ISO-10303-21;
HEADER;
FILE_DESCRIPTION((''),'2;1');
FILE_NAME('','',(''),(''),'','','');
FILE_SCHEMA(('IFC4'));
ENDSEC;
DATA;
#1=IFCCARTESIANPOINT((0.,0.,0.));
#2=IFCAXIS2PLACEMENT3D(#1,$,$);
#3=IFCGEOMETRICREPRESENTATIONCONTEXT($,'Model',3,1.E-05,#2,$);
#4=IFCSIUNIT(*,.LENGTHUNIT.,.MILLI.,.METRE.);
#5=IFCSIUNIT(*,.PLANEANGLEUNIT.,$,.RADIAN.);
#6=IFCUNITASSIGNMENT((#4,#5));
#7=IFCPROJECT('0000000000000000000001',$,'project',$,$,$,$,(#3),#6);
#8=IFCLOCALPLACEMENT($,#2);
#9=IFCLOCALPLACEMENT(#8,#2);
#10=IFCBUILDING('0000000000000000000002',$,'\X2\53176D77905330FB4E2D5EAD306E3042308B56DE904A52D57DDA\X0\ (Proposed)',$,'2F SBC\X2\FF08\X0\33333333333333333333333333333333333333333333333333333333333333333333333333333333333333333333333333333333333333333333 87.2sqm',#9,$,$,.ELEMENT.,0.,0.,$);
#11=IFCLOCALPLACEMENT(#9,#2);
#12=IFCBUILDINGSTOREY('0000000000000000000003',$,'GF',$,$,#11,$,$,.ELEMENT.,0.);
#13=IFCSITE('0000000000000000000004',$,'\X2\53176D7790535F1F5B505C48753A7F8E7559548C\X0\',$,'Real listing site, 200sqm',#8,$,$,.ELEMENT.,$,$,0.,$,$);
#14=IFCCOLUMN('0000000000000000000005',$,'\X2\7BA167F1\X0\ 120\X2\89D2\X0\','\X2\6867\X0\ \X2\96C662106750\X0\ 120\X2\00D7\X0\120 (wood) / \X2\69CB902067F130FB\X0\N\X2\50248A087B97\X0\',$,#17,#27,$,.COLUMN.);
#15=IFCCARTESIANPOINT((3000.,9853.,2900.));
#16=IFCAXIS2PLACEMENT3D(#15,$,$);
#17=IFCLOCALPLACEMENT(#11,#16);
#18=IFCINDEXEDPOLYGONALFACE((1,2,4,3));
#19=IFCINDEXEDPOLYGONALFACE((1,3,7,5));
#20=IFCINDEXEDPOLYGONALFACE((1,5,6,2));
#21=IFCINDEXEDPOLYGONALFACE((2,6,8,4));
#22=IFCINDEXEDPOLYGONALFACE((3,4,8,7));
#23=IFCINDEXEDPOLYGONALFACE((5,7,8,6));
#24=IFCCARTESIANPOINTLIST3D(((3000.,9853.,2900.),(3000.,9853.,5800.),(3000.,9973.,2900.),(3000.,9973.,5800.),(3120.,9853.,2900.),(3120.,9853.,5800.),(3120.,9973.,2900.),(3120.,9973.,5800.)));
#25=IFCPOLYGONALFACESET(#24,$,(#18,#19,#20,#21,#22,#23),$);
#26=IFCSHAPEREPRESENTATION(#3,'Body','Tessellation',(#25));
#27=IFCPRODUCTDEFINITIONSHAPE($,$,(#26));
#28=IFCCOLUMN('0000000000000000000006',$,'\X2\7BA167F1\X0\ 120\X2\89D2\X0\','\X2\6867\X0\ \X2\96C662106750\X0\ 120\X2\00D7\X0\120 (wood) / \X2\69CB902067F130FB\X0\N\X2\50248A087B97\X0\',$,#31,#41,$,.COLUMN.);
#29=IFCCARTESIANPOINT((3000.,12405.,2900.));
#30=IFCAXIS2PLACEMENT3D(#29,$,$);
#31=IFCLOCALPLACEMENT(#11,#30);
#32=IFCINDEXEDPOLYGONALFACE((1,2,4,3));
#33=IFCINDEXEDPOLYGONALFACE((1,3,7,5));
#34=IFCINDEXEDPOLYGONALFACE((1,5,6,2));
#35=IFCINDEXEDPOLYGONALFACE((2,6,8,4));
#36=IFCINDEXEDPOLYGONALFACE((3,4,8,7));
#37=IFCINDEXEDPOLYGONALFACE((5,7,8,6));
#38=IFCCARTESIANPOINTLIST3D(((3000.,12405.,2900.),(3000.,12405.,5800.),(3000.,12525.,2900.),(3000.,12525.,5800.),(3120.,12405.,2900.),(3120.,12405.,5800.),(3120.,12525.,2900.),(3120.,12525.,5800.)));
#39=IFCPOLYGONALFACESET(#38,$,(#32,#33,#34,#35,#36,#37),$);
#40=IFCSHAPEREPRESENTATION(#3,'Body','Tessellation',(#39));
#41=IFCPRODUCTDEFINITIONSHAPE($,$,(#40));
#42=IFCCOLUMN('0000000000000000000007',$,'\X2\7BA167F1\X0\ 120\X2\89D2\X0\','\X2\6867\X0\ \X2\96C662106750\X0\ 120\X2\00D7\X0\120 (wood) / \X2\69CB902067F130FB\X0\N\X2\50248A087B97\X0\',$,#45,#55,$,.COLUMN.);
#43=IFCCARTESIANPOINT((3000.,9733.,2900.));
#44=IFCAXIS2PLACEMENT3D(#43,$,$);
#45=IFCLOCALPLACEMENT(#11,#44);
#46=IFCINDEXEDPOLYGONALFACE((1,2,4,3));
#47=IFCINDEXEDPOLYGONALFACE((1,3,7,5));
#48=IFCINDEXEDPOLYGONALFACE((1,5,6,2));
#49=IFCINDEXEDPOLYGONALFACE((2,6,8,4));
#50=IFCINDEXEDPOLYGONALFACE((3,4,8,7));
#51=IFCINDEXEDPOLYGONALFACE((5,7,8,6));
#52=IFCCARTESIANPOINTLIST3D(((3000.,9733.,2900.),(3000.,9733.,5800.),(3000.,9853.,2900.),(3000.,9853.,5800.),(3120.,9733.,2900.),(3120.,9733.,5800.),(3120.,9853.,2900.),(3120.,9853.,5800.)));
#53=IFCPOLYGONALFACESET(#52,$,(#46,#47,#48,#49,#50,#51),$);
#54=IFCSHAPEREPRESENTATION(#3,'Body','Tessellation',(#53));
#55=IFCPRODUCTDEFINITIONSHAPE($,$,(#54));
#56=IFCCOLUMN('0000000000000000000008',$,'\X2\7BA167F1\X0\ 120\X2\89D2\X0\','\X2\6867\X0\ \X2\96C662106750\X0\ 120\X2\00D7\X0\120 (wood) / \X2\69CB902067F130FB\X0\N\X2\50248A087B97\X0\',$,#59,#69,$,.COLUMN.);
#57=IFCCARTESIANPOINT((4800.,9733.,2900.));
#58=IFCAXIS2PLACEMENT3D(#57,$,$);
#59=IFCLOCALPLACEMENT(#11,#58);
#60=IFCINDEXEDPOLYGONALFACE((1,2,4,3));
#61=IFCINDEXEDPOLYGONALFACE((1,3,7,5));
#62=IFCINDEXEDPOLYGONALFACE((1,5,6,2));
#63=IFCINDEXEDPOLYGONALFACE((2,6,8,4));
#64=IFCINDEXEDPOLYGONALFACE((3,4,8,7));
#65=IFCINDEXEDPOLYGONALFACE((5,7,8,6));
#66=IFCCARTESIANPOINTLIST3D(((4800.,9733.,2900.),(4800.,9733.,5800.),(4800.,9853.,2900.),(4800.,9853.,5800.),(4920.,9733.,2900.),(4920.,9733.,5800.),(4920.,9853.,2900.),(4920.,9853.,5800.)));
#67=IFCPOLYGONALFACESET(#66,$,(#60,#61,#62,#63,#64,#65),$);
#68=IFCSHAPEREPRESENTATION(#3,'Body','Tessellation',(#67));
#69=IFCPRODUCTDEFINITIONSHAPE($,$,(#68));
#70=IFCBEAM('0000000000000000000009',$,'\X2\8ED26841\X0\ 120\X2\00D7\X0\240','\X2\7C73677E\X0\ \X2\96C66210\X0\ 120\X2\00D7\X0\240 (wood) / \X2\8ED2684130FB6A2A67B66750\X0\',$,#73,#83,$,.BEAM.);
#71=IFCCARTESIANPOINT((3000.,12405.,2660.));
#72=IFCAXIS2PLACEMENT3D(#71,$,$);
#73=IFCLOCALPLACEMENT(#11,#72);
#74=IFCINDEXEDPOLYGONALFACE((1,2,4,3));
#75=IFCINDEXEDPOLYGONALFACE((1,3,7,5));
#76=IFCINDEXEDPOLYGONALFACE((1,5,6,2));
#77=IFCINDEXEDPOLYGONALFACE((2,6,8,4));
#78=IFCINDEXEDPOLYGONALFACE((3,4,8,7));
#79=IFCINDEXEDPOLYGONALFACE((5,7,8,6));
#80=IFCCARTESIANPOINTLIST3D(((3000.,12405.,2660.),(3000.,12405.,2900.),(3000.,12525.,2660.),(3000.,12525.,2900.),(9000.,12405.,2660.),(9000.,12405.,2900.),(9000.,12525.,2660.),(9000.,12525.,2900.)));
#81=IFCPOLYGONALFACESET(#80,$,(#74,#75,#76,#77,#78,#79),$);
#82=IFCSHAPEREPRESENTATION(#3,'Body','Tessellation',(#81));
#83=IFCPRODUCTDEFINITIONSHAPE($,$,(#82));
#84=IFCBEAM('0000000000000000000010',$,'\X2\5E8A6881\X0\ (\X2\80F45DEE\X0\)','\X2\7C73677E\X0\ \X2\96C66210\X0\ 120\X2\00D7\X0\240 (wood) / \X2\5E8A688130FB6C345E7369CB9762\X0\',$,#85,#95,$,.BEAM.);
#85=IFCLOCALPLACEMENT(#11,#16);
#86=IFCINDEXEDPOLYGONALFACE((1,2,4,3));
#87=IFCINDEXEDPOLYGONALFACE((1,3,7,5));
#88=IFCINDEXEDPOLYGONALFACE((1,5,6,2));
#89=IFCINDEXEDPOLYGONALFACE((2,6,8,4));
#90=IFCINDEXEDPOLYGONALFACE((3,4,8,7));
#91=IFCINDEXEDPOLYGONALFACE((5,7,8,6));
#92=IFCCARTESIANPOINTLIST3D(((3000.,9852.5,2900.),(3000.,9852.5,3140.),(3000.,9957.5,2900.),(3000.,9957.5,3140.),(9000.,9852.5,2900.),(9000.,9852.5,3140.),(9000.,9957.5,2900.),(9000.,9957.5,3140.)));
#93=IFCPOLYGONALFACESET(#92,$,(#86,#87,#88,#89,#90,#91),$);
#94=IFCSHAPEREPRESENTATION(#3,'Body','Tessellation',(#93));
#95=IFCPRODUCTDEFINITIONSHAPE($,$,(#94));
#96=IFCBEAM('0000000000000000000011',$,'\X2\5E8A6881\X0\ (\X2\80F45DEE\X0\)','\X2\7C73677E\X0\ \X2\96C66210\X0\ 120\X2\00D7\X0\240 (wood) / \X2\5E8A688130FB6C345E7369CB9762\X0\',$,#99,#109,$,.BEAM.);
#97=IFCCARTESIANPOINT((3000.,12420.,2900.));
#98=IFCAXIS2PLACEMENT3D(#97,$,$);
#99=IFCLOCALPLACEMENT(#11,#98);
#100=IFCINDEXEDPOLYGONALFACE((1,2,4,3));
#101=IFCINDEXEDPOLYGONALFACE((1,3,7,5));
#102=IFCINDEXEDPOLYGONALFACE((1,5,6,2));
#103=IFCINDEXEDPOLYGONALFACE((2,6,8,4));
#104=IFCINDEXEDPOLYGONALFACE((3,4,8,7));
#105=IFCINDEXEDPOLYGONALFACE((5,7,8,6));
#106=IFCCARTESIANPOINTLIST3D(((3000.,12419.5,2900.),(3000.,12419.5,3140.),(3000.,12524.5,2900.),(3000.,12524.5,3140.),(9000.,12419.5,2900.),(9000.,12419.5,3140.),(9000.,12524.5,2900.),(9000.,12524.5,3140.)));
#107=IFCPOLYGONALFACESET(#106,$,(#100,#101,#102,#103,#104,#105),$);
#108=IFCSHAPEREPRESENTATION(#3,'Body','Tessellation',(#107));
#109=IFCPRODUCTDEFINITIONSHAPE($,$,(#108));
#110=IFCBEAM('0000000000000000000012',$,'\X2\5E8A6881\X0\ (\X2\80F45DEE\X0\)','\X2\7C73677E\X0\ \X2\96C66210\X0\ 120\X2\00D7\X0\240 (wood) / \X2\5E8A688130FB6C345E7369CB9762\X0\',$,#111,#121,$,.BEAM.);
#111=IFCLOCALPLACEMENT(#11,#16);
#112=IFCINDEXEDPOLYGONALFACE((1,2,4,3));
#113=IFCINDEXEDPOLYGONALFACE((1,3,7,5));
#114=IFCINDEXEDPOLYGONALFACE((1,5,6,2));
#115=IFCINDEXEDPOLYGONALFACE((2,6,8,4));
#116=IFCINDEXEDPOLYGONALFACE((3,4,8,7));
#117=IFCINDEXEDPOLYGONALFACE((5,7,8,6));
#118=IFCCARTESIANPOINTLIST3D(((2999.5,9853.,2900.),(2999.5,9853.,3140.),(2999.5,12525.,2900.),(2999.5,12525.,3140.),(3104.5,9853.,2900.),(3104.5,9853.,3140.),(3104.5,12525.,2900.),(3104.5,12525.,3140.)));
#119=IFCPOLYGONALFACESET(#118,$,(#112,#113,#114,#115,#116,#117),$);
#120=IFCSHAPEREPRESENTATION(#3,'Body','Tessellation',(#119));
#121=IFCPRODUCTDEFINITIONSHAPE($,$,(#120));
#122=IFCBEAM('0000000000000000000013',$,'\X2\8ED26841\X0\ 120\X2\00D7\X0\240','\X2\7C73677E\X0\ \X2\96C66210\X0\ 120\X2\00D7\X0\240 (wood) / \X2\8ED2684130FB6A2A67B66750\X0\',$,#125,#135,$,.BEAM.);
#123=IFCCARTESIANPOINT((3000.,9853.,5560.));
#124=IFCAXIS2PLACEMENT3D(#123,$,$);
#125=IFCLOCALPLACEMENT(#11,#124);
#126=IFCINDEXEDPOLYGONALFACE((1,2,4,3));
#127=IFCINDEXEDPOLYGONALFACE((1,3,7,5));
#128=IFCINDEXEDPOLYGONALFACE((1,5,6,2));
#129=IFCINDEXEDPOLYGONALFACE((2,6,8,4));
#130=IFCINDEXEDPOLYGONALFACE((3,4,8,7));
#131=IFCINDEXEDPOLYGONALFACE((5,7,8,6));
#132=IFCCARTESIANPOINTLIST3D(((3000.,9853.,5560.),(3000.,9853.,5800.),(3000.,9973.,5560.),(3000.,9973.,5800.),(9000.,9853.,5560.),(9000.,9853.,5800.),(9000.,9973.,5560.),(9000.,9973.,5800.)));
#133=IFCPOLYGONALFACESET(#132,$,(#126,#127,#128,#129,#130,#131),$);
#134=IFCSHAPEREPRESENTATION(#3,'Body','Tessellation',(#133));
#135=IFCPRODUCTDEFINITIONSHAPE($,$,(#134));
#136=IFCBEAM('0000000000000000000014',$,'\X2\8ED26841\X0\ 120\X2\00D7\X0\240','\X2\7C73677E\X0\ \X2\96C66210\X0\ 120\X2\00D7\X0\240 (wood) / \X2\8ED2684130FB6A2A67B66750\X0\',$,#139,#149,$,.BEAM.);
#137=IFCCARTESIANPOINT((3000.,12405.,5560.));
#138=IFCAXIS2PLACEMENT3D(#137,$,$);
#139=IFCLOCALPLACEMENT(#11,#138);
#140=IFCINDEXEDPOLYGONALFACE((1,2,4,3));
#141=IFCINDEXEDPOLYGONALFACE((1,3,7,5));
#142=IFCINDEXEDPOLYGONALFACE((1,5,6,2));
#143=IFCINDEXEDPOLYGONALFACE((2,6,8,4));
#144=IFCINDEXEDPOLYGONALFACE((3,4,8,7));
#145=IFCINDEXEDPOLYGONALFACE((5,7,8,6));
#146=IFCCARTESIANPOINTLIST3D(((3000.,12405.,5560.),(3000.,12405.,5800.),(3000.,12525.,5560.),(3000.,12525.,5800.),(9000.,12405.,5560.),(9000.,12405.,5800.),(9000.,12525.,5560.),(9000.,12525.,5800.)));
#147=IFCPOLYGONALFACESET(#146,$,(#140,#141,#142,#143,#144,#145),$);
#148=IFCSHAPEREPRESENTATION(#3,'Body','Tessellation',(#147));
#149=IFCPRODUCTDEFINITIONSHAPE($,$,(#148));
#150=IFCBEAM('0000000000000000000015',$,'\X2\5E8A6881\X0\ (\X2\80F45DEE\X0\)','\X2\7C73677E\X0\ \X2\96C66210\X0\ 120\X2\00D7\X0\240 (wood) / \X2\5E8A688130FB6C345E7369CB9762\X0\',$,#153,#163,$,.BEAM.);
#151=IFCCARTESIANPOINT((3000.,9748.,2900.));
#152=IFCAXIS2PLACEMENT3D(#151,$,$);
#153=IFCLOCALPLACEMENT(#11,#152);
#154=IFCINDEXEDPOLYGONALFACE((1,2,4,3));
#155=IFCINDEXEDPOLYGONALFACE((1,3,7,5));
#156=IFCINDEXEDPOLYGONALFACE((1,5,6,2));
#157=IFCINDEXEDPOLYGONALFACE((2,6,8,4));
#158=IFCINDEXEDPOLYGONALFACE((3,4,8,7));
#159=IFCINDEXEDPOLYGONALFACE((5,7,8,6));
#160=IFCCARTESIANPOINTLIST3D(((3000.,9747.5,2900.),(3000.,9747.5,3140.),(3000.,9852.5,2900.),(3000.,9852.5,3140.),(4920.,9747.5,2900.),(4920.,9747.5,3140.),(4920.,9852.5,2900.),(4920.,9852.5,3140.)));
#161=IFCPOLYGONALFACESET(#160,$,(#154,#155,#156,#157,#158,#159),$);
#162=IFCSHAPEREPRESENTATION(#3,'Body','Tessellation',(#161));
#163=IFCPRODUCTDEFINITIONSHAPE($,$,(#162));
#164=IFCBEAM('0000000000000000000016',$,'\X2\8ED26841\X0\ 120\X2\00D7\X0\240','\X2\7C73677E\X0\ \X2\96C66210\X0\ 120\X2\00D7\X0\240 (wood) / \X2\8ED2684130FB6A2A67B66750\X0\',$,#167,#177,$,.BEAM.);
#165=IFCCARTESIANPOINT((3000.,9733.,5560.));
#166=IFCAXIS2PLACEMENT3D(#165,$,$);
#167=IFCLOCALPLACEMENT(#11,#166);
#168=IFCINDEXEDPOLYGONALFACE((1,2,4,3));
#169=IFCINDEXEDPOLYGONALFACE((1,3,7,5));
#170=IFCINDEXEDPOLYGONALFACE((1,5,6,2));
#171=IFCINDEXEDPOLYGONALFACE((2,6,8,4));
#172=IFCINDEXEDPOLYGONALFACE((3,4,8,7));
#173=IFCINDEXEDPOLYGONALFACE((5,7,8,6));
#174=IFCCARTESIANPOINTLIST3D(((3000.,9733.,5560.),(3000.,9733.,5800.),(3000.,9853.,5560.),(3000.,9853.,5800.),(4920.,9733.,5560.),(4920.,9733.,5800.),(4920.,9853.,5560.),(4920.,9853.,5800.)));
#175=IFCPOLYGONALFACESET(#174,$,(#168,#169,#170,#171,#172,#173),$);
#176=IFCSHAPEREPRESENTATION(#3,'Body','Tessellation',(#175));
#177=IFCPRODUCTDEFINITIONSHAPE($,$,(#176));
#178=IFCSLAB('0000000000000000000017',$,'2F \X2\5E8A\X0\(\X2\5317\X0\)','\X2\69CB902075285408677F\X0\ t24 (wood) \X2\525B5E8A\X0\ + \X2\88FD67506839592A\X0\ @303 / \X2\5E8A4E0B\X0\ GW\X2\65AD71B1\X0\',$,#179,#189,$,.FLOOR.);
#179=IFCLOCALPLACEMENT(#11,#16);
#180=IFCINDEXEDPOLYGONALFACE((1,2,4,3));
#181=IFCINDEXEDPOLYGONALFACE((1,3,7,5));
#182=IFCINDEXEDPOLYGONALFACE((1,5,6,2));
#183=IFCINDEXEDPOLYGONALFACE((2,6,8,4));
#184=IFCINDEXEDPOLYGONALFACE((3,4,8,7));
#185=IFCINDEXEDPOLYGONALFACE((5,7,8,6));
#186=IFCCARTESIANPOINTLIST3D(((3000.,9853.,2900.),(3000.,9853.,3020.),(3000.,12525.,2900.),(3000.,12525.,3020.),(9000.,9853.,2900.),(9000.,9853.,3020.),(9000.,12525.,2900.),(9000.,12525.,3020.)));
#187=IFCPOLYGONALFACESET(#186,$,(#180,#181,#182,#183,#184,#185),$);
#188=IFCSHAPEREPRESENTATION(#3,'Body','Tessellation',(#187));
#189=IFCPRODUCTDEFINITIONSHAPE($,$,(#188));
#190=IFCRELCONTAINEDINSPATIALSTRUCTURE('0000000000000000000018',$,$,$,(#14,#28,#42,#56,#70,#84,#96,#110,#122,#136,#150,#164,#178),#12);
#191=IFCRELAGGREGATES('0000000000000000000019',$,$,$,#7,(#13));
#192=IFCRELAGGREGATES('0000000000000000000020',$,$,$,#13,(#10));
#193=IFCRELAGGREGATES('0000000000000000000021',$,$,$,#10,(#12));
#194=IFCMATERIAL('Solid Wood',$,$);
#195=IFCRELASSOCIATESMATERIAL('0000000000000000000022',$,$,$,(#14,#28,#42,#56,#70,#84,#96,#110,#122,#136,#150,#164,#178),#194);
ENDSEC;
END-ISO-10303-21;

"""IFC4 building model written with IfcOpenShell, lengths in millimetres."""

from ifc_helpers import new_model, si_unit, frame, frame_2d, origin, place, context, project, spatial, rectangle, extrude, material, element, save


model = new_model("IFC4")

# Units and contexts
model_context = context("Model", 3, precision=1e-05, world=origin())
ifc_project = project(units=[si_unit("LENGTHUNIT", "METRE", prefix="MILLI"), si_unit("PLANEANGLEUNIT", "RADIAN")], contexts=[model_context])

# Site, building, storey
site_placement = place(None, origin())
site = spatial("IfcSite", under=ifc_project, at=site_placement, Name="北海道弟子屈町美留和", ObjectType="Real listing site, 200sqm", CompositionType="ELEMENT", RefElevation=0.0)
building_placement = place(site_placement, origin())
building = spatial("IfcBuilding", under=site, at=building_placement, Name="北海道・中庭のある回遊動線 (Proposed)", ObjectType="2F SBC（33333333333333333333333333333333333333333333333333333333333333333333333333333333333333333333333333333333333333333333 87.2sqm", CompositionType="ELEMENT", ElevationOfRefHeight=0.0, ElevationOfTerrain=0.0)
storey_placement = place(building_placement, origin())
storey = spatial("IfcBuildingStorey", under=building, at=storey_placement, Name="GF", CompositionType="ELEMENT", Elevation=0.0)

# Columns
ifc_material_1 = material(Name="Solid Wood")
column_1_placement = place(storey_placement, frame((3000.0, 9853.0, 2900.0)))
element("IfcColumn", 1, at=column_1_placement, inside=storey, material=ifc_material_1, Name="管柱 120角", Description="桧 集成材 120×120 (wood) / 構造柱・N値計算", PredefinedType="COLUMN", context=model_context, shape_type="SweptSolid", body=[
    extrude(rectangle(XDim=120.0, YDim=120.0, at=frame_2d((60.0, 60.0))), frame((3000.0, 9853.0, 2900.0)), (0.0, 0.0, 1.0), 2900.0),
])
column_2_placement = place(storey_placement, frame((3000.0, 12405.0, 2900.0)))
element("IfcColumn", 2, at=column_2_placement, inside=storey, material=ifc_material_1, Name="管柱 120角", Description="桧 集成材 120×120 (wood) / 構造柱・N値計算", PredefinedType="COLUMN", context=model_context, shape_type="SweptSolid", body=[
    extrude(rectangle(XDim=120.0, YDim=120.0, at=frame_2d((60.0, 60.0))), frame((3000.0, 12405.0, 2900.0)), (0.0, 0.0, 1.0), 2900.0),
])
column_3_placement = place(storey_placement, frame((3000.0, 9733.0, 2900.0)))
element("IfcColumn", 3, at=column_3_placement, inside=storey, material=ifc_material_1, Name="管柱 120角", Description="桧 集成材 120×120 (wood) / 構造柱・N値計算", PredefinedType="COLUMN", context=model_context, shape_type="SweptSolid", body=[
    extrude(rectangle(XDim=120.0, YDim=120.0, at=frame_2d((60.0, 60.0))), frame((3000.0, 9733.0, 2900.0)), (0.0, 0.0, 1.0), 2900.0),
])
column_4_placement = place(storey_placement, frame((4800.0, 9733.0, 2900.0)))
element("IfcColumn", 4, at=column_4_placement, inside=storey, material=ifc_material_1, Name="管柱 120角", Description="桧 集成材 120×120 (wood) / 構造柱・N値計算", PredefinedType="COLUMN", context=model_context, shape_type="SweptSolid", body=[
    extrude(rectangle(XDim=120.0, YDim=120.0, at=frame_2d((60.0, 60.0))), frame((4800.0, 9733.0, 2900.0)), (0.0, 0.0, 1.0), 2900.0),
])

# Beams
beam_1_placement = place(storey_placement, frame((3000.0, 12405.0, 2660.0)))
element("IfcBeam", 5, at=beam_1_placement, inside=storey, material=ifc_material_1, Name="軒桁 120×240", Description="米松 集成 120×240 (wood) / 軒桁・横架材", PredefinedType="BEAM", context=model_context, shape_type="SweptSolid", body=[
    extrude(rectangle(XDim=6000.0, YDim=120.0, at=frame_2d((3000.0, 60.0))), frame((3000.0, 12405.0, 2660.0)), (0.0, 0.0, 1.0), 240.0),
])
beam_2_placement = place(storey_placement, frame((3000.0, 9853.0, 2900.0)))
element("IfcBeam", 6, at=beam_2_placement, inside=storey, material=ifc_material_1, Name="床梁 (胴差)", Description="米松 集成 120×240 (wood) / 床梁・水平構面", PredefinedType="BEAM", context=model_context, shape_type="SweptSolid", body=[
    extrude(rectangle(XDim=6000.0, YDim=105.0, at=frame_2d((3000.0, 52.0))), frame((3000.0, 9853.0, 2900.0)), (0.0, 0.0, 1.0), 240.0),
])
beam_3_placement = place(storey_placement, frame((3000.0, 12420.0, 2900.0)))
element("IfcBeam", 7, at=beam_3_placement, inside=storey, material=ifc_material_1, Name="床梁 (胴差)", Description="米松 集成 120×240 (wood) / 床梁・水平構面", PredefinedType="BEAM", context=model_context, shape_type="SweptSolid", body=[
    extrude(rectangle(XDim=6000.0, YDim=105.0, at=frame_2d((3000.0, 52.0))), frame((3000.0, 12420.0, 2900.0)), (0.0, 0.0, 1.0), 240.0),
])
beam_4_placement = place(storey_placement, frame((3000.0, 9853.0, 2900.0)))
element("IfcBeam", 8, at=beam_4_placement, inside=storey, material=ifc_material_1, Name="床梁 (胴差)", Description="米松 集成 120×240 (wood) / 床梁・水平構面", PredefinedType="BEAM", context=model_context, shape_type="SweptSolid", body=[
    extrude(rectangle(XDim=105.0, YDim=2672.0, at=frame_2d((52.0, 1336.0))), frame((3000.0, 9853.0, 2900.0)), (0.0, 0.0, 1.0), 240.0),
])
beam_5_placement = place(storey_placement, frame((3000.0, 9853.0, 5560.0)))
element("IfcBeam", 9, at=beam_5_placement, inside=storey, material=ifc_material_1, Name="軒桁 120×240", Description="米松 集成 120×240 (wood) / 軒桁・横架材", PredefinedType="BEAM", context=model_context, shape_type="SweptSolid", body=[
    extrude(rectangle(XDim=6000.0, YDim=120.0, at=frame_2d((3000.0, 60.0))), frame((3000.0, 9853.0, 5560.0)), (0.0, 0.0, 1.0), 240.0),
])
beam_6_placement = place(storey_placement, frame((3000.0, 12405.0, 5560.0)))
element("IfcBeam", 10, at=beam_6_placement, inside=storey, material=ifc_material_1, Name="軒桁 120×240", Description="米松 集成 120×240 (wood) / 軒桁・横架材", PredefinedType="BEAM", context=model_context, shape_type="SweptSolid", body=[
    extrude(rectangle(XDim=6000.0, YDim=120.0, at=frame_2d((3000.0, 60.0))), frame((3000.0, 12405.0, 5560.0)), (0.0, 0.0, 1.0), 240.0),
])
beam_7_placement = place(storey_placement, frame((3000.0, 9748.0, 2900.0)))
element("IfcBeam", 11, at=beam_7_placement, inside=storey, material=ifc_material_1, Name="床梁 (胴差)", Description="米松 集成 120×240 (wood) / 床梁・水平構面", PredefinedType="BEAM", context=model_context, shape_type="SweptSolid", body=[
    extrude(rectangle(XDim=1920.0, YDim=105.0, at=frame_2d((960.0, 52.0))), frame((3000.0, 9748.0, 2900.0)), (0.0, 0.0, 1.0), 240.0),
])
beam_8_placement = place(storey_placement, frame((3000.0, 9733.0, 5560.0)))
element("IfcBeam", 12, at=beam_8_placement, inside=storey, material=ifc_material_1, Name="軒桁 120×240", Description="米松 集成 120×240 (wood) / 軒桁・横架材", PredefinedType="BEAM", context=model_context, shape_type="SweptSolid", body=[
    extrude(rectangle(XDim=1920.0, YDim=120.0, at=frame_2d((960.0, 60.0))), frame((3000.0, 9733.0, 5560.0)), (0.0, 0.0, 1.0), 240.0),
])

# Slab
slab_placement = place(storey_placement, frame((3000.0, 9853.0, 2900.0)))
element("IfcSlab", 13, at=slab_placement, inside=storey, material=ifc_material_1, Name="2F 床(北)", Description="構造用合板 t24 (wood) 剛床 + 製材根太 @303 / 床下 GW断熱", PredefinedType="FLOOR", context=model_context, shape_type="SweptSolid", body=[
    extrude(rectangle(XDim=6000.0, YDim=2672.0, at=frame_2d((3000.0, 1336.0))), frame((3000.0, 9853.0, 2900.0)), (0.0, 0.0, 1.0), 120.0),
])

save(model, "model.ifc")
